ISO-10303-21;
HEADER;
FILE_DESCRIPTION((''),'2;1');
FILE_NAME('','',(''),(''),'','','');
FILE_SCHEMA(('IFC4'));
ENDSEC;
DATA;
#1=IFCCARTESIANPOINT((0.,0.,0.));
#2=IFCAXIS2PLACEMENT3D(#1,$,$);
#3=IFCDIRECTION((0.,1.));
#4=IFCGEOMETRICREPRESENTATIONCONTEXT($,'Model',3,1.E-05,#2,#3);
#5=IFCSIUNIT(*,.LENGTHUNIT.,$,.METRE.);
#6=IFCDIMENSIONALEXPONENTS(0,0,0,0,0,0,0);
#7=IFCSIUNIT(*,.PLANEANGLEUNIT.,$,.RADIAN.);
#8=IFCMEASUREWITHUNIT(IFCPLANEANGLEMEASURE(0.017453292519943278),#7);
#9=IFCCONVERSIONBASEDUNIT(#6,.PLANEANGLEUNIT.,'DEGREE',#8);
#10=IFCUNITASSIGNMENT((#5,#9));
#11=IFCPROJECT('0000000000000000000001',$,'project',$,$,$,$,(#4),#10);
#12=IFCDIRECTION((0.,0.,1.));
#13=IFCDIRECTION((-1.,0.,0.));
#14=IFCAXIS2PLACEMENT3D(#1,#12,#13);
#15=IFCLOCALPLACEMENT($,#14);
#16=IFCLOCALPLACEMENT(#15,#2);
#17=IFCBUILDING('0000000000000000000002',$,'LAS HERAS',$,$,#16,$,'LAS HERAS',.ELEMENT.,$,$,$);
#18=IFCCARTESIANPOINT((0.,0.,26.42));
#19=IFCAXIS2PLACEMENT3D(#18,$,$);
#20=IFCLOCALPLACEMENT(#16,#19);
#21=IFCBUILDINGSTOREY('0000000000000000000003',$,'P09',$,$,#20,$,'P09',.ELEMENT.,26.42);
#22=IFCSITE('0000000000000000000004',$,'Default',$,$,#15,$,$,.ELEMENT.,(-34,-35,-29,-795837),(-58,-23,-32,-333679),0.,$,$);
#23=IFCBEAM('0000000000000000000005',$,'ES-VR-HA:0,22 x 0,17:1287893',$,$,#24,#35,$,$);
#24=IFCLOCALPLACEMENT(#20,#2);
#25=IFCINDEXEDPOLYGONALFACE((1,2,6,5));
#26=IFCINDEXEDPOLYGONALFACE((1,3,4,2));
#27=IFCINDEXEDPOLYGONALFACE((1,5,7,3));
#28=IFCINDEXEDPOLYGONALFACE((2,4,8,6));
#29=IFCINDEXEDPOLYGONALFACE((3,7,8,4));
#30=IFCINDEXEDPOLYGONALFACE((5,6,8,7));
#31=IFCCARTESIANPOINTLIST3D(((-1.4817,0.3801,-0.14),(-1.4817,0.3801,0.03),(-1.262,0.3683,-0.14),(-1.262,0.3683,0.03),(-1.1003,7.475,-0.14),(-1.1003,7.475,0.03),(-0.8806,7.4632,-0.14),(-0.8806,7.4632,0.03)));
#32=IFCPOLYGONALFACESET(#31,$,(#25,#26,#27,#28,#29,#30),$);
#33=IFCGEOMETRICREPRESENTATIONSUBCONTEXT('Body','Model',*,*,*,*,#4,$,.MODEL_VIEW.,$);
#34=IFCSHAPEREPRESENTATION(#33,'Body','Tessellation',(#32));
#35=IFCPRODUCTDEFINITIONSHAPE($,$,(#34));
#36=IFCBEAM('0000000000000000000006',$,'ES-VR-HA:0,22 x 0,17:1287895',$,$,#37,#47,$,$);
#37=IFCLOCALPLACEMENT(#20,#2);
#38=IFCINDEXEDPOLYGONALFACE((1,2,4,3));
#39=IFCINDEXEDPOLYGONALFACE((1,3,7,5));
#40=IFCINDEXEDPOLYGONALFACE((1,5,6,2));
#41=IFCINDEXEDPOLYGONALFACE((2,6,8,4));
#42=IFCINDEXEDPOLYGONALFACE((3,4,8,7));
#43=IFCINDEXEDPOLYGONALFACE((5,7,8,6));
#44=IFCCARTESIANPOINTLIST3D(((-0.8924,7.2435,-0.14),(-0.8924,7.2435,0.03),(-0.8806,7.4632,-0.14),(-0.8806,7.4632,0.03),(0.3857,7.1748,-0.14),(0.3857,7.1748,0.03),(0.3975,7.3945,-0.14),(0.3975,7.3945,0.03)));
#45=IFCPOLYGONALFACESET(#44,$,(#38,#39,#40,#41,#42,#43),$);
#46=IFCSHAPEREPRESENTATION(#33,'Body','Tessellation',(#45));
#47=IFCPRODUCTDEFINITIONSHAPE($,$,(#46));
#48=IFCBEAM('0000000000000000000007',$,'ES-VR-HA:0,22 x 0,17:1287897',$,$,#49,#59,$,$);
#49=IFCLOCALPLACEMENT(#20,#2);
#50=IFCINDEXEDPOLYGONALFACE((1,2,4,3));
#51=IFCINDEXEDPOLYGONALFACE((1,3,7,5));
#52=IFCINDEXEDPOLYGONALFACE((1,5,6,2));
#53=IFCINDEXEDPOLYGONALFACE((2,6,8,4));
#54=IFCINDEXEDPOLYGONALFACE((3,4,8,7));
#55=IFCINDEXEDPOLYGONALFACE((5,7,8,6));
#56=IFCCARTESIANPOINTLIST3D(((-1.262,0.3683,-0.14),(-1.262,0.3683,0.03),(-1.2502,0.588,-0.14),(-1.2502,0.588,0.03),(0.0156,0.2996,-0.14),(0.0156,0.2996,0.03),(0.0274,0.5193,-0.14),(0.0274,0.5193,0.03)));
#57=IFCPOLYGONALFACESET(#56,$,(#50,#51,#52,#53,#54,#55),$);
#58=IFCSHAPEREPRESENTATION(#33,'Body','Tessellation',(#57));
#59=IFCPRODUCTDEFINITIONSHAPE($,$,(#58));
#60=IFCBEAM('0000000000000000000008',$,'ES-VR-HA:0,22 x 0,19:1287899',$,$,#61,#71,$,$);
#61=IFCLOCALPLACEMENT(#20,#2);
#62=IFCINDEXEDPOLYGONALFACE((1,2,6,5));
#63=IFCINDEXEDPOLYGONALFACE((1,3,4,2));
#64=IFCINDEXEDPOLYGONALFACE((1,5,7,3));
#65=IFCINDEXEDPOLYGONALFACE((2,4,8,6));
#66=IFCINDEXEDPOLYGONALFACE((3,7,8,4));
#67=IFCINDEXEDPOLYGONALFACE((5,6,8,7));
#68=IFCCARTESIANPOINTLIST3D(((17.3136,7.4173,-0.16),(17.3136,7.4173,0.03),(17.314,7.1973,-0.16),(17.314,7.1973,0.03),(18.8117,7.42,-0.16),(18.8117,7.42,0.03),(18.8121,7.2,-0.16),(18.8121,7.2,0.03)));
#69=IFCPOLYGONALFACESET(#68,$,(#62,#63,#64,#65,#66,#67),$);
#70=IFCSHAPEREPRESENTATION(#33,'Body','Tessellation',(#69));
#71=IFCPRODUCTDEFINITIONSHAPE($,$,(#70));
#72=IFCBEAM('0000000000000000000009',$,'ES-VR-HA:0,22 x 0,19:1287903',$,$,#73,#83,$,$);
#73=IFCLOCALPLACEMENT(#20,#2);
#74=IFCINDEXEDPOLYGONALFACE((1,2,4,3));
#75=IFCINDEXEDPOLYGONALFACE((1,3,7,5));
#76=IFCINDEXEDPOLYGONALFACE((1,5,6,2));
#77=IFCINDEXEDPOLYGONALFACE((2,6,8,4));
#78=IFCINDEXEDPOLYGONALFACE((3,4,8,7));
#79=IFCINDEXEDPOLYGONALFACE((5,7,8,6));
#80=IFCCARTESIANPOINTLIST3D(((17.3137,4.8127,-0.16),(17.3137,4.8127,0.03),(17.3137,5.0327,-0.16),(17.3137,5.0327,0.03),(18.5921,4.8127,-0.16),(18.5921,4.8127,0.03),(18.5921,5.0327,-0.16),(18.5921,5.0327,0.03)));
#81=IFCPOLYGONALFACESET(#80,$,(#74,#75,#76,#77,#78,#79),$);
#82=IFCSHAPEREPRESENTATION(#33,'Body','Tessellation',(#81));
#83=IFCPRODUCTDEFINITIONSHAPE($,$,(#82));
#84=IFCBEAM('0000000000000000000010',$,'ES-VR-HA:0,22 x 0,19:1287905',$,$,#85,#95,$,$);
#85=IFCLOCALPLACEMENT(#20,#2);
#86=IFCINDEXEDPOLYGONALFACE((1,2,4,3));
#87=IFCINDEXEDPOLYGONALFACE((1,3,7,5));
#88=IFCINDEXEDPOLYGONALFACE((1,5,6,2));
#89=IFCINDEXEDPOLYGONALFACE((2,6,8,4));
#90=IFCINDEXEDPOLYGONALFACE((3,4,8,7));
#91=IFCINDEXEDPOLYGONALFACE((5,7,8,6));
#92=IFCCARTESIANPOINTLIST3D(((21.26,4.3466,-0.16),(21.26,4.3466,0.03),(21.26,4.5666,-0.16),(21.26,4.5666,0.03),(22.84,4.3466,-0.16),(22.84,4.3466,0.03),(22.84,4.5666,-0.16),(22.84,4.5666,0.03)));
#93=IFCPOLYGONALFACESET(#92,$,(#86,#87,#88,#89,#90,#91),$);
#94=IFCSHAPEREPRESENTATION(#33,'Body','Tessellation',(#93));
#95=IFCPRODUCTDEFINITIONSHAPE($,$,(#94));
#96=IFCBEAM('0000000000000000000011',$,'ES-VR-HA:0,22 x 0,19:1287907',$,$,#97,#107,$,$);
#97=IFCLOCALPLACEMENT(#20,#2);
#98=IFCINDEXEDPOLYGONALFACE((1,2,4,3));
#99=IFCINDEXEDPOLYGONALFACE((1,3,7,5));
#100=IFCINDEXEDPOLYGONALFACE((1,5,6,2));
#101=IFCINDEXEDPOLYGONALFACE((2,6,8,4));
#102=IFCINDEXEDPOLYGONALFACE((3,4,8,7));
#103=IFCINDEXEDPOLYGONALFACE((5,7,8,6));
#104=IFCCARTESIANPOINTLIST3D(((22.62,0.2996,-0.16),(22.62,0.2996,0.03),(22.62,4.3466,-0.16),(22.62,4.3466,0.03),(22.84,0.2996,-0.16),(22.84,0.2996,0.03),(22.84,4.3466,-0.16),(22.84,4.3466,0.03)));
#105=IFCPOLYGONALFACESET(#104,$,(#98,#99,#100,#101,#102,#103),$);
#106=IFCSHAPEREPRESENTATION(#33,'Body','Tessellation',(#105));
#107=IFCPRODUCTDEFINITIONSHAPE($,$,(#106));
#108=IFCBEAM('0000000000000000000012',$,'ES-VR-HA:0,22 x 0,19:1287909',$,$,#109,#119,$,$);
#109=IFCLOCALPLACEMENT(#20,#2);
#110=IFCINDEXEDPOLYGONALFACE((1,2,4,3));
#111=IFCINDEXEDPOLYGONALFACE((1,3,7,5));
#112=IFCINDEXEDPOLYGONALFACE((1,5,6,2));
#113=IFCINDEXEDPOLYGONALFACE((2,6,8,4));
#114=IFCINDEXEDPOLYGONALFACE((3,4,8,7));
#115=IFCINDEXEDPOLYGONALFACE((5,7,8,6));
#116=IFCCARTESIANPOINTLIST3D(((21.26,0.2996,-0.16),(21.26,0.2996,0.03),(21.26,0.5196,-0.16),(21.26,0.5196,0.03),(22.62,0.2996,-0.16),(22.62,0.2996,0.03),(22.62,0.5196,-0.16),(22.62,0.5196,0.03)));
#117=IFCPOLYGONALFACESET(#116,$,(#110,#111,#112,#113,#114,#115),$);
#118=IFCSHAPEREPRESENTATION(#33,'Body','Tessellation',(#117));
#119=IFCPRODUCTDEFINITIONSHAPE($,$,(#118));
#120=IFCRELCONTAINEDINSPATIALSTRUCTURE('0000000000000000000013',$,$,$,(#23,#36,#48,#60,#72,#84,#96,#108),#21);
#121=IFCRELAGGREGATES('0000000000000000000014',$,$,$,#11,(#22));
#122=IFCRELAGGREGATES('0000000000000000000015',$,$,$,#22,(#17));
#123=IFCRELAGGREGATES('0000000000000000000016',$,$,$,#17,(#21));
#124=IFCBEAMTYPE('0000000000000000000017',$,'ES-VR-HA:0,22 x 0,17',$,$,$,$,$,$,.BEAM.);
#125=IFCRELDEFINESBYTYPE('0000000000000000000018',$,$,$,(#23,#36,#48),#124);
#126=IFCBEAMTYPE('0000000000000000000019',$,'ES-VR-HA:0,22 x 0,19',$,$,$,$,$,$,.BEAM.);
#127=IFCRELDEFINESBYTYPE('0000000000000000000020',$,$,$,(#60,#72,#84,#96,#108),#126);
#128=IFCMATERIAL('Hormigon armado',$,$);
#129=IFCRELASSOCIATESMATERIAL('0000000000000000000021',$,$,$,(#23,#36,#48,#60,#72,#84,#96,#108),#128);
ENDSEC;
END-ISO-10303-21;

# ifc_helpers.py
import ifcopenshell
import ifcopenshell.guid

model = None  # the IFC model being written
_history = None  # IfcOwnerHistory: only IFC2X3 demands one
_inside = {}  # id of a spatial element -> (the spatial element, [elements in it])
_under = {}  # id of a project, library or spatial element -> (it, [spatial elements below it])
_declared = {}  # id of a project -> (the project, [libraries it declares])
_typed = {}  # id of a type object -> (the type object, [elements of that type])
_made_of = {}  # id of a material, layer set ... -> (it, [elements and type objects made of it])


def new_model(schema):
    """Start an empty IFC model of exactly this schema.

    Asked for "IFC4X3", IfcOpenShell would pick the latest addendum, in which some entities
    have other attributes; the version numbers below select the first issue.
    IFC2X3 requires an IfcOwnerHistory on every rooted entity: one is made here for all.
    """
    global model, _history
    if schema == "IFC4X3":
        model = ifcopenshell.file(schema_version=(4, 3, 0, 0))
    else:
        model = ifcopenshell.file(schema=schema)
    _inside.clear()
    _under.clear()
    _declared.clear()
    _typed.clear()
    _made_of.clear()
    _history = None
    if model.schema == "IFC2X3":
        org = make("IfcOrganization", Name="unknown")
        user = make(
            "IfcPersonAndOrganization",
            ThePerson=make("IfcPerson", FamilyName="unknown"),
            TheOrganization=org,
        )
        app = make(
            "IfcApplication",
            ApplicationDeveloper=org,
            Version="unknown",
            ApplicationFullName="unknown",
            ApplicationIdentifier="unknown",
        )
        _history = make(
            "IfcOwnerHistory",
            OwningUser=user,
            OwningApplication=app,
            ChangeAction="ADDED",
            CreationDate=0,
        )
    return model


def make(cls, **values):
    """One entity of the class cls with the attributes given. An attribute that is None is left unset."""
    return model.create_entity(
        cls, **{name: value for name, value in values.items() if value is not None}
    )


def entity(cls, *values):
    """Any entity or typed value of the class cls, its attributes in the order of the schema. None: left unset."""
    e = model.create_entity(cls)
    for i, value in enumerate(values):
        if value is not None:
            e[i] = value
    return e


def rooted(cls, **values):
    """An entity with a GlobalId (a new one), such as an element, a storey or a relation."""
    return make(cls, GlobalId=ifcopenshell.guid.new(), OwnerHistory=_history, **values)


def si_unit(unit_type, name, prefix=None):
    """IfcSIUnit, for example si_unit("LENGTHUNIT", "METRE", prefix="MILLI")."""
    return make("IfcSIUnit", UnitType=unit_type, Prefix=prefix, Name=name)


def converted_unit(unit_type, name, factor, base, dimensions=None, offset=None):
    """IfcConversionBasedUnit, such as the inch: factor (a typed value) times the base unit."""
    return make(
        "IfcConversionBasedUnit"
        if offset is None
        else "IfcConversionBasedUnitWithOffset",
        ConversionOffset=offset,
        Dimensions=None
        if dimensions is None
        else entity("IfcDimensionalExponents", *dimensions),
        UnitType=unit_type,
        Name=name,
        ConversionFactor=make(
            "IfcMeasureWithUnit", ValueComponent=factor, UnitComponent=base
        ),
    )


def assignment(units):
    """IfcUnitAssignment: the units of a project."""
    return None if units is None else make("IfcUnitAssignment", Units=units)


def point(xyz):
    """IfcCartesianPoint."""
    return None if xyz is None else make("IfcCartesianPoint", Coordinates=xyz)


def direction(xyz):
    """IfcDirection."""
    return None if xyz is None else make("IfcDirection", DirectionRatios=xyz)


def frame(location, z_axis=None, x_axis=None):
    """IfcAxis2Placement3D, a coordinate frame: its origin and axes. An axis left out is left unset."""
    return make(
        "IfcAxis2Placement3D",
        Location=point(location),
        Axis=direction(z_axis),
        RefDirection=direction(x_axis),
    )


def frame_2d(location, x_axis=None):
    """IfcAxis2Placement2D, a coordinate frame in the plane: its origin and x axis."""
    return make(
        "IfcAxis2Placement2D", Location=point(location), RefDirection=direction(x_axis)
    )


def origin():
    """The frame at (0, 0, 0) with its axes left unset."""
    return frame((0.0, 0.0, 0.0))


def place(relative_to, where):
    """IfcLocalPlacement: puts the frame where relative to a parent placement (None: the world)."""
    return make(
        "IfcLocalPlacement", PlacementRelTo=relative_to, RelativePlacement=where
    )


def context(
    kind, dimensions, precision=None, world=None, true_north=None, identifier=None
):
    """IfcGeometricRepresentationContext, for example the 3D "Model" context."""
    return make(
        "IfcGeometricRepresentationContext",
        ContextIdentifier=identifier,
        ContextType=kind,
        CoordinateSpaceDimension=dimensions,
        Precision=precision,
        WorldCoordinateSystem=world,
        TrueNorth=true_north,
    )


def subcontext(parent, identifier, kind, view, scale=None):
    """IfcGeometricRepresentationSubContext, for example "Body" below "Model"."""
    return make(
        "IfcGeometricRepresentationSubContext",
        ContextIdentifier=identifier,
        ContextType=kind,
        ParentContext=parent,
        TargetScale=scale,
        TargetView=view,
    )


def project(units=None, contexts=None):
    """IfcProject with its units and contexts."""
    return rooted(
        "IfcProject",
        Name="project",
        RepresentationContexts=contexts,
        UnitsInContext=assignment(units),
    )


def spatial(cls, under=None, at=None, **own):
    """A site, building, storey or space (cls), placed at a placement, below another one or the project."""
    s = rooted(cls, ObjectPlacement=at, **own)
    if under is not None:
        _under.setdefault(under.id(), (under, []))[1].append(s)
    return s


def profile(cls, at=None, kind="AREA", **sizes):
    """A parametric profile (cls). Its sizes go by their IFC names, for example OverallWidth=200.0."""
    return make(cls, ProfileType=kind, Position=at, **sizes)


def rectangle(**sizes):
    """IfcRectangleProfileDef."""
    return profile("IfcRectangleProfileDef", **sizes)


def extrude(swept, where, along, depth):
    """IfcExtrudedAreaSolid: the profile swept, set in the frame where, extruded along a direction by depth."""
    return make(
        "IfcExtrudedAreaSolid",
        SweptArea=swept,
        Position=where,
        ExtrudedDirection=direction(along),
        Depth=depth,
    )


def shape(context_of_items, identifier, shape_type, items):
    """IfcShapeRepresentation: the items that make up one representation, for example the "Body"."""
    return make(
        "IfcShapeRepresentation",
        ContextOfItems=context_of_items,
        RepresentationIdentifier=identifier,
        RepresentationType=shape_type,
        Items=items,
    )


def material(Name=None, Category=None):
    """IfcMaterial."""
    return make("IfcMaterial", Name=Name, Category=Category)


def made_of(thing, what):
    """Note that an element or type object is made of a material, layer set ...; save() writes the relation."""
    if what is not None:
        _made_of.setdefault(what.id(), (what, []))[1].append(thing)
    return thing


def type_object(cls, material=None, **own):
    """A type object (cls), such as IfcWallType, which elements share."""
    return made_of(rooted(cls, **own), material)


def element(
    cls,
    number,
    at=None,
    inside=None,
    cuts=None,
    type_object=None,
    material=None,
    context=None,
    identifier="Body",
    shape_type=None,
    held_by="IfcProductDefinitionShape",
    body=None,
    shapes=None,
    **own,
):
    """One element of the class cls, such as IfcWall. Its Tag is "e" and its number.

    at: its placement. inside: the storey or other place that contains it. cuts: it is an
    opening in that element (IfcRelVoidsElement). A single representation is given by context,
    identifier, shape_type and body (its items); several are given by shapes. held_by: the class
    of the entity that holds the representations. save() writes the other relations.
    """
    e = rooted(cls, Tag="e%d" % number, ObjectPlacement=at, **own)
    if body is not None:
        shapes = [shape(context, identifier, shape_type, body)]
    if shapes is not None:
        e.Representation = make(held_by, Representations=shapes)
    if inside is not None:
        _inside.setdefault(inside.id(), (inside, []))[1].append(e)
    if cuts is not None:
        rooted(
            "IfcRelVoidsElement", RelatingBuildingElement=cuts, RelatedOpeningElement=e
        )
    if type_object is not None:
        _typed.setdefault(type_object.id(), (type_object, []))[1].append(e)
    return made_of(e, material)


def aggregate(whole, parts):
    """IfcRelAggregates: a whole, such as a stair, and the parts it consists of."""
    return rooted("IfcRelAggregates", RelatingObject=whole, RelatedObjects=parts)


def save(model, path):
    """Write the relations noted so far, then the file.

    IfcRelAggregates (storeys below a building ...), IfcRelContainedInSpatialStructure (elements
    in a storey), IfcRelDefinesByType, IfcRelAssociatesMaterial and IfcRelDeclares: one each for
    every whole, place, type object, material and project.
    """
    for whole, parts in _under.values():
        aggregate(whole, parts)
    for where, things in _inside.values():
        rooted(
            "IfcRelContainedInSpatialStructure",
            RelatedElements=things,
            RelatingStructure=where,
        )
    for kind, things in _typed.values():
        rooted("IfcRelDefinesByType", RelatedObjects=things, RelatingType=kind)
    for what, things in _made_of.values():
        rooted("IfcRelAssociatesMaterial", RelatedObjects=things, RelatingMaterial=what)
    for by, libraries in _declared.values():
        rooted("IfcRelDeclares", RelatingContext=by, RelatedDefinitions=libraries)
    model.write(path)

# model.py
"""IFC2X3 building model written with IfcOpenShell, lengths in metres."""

from ifc_helpers import new_model, entity, si_unit, converted_unit, direction, frame, frame_2d, origin, place, context, subcontext, project, spatial, rectangle, extrude, material, type_object, element, save


model = new_model("IFC2X3")

# Units and contexts
model_context = context("Model", 3, precision=1e-05, world=origin(), true_north=direction((0.0, 1.0)))
body_context = subcontext(model_context, "Body", "Model", "MODEL_VIEW")
ifc_project = project(units=[si_unit("LENGTHUNIT", "METRE"), converted_unit("PLANEANGLEUNIT", "DEGREE", entity("IfcPlaneAngleMeasure", 0.017453292519943278), si_unit("PLANEANGLEUNIT", "RADIAN"), dimensions=[0, 0, 0, 0, 0, 0, 0])], contexts=[model_context])

# Site, building, storey
site_placement = place(None, frame((0.0, 0.0, 0.0), z_axis=(0.0, 0.0, 1.0), x_axis=(-1.0, 0.0, 0.0)))
site = spatial("IfcSite", under=ifc_project, at=site_placement, Name="Default", CompositionType="ELEMENT", RefLatitude=(-34, -35, -29, -795837), RefLongitude=(-58, -23, -32, -333679), RefElevation=0.0)
building_placement = place(site_placement, origin())
building = spatial("IfcBuilding", under=site, at=building_placement, Name="LAS HERAS", LongName="LAS HERAS", CompositionType="ELEMENT")
storey_placement = place(building_placement, frame((0.0, 0.0, 26.42)))
storey = spatial("IfcBuildingStorey", under=building, at=storey_placement, Name="P09", LongName="P09", CompositionType="ELEMENT", Elevation=26.42)

# Beams
ifc_material = material(Name="Hormigon armado")
beam_type_1 = type_object("IfcBeamType", Name="ES-VR-HA:0,22 x 0,17", PredefinedType="BEAM")
beam_1_placement = place(storey_placement, frame((-0.9963, 7.3593, 0.03), z_axis=(0.0, 0.0, 1.0), x_axis=(-0.05369, -0.998558, 0.0)))
element("IfcBeam", 1, at=beam_1_placement, inside=storey, type_object=beam_type_1, material=ifc_material, Name="ES-VR-HA:0,22 x 0,17:1287893", context=body_context, shape_type="SweptSolid", body=[
    extrude(rectangle(XDim=0.17, YDim=0.22, at=frame_2d((0.0, 0.0), x_axis=(1.0, 0.0))), frame((-0.11, 0.0, -0.085), z_axis=(1.0, 0.0, 0.0), x_axis=(0.0, 0.0, -1.0)), (0.0, 0.0, 1.0), 7.1052),
])
beam_2_placement = place(storey_placement, frame((0.3916, 7.2846, 0.03), z_axis=(0.0, 0.0, 1.0), x_axis=(-0.998558, 0.05368, 0.0)))
element("IfcBeam", 2, at=beam_2_placement, inside=storey, type_object=beam_type_1, material=ifc_material, Name="ES-VR-HA:0,22 x 0,17:1287895", context=body_context, shape_type="SweptSolid", body=[
    extrude(rectangle(XDim=0.17, YDim=0.22, at=frame_2d((0.0, 0.0), x_axis=(1.0, 0.0))), frame((0.0, 0.0, -0.085), z_axis=(1.0, 0.0, 0.0), x_axis=(0.0, 0.0, -1.0)), (0.0, 0.0, 1.0), 1.28),
])
beam_3_placement = place(storey_placement, frame((0.0215, 0.4094, 0.03), z_axis=(0.0, 0.0, 1.0), x_axis=(-0.998558, 0.05369, 0.0)))
element("IfcBeam", 3, at=beam_3_placement, inside=storey, type_object=beam_type_1, material=ifc_material, Name="ES-VR-HA:0,22 x 0,17:1287897", context=body_context, shape_type="SweptSolid", body=[
    extrude(rectangle(XDim=0.17, YDim=0.22, at=frame_2d((0.0, 0.0), x_axis=(1.0, 0.0))), frame((0.0, 0.0, -0.085), z_axis=(1.0, 0.0, 0.0), x_axis=(0.0, 0.0, -1.0)), (0.0, 0.0, 1.0), 1.2795),
])
beam_type_2 = type_object("IfcBeamType", Name="ES-VR-HA:0,22 x 0,19", PredefinedType="BEAM")
beam_4_placement = place(storey_placement, frame((17.3138, 7.3073, 0.03), z_axis=(0.0, 0.0, 1.0), x_axis=(0.999998, 0.001781, 0.0)))
element("IfcBeam", 4, at=beam_4_placement, inside=storey, type_object=beam_type_2, material=ifc_material, Name="ES-VR-HA:0,22 x 0,19:1287899", context=body_context, shape_type="SweptSolid", body=[
    extrude(rectangle(XDim=0.19, YDim=0.22, at=frame_2d((0.0, 0.0), x_axis=(1.0, 0.0))), frame((0.0, 0.0, -0.095), z_axis=(1.0, 0.0, 0.0), x_axis=(0.0, 0.0, -1.0)), (0.0, 0.0, 1.0), 1.4981),
])
beam_5_placement = place(storey_placement, frame((17.3137, 4.9227, 0.03)))
element("IfcBeam", 5, at=beam_5_placement, inside=storey, type_object=beam_type_2, material=ifc_material, Name="ES-VR-HA:0,22 x 0,19:1287903", context=body_context, shape_type="SweptSolid", body=[
    extrude(rectangle(XDim=0.19, YDim=0.22, at=frame_2d((0.0, 0.0), x_axis=(1.0, 0.0))), frame((0.0, 0.0, -0.095), z_axis=(1.0, 0.0, 0.0), x_axis=(0.0, 0.0, -1.0)), (0.0, 0.0, 1.0), 1.2784),
])
beam_6_placement = place(storey_placement, frame((21.26, 4.4566, 0.03)))
element("IfcBeam", 6, at=beam_6_placement, inside=storey, type_object=beam_type_2, material=ifc_material, Name="ES-VR-HA:0,22 x 0,19:1287905", context=body_context, shape_type="SweptSolid", body=[
    extrude(rectangle(XDim=0.19, YDim=0.22, at=frame_2d((0.0, 0.0), x_axis=(1.0, 0.0))), frame((0.0, 0.0, -0.095), z_axis=(1.0, 0.0, 0.0), x_axis=(0.0, 0.0, -1.0)), (0.0, 0.0, 1.0), 1.58),
])
beam_7_placement = place(storey_placement, frame((22.73, 4.4566, 0.03), z_axis=(0.0, 0.0, 1.0), x_axis=(0.0, -1.0, 0.0)))
element("IfcBeam", 7, at=beam_7_placement, inside=storey, type_object=beam_type_2, material=ifc_material, Name="ES-VR-HA:0,22 x 0,19:1287907", context=body_context, shape_type="SweptSolid", body=[
    extrude(rectangle(XDim=0.19, YDim=0.22, at=frame_2d((0.0, 0.0), x_axis=(1.0, 0.0))), frame((0.11, 0.0, -0.095), z_axis=(1.0, 0.0, 0.0), x_axis=(0.0, 0.0, -1.0)), (0.0, 0.0, 1.0), 4.0471),
])
beam_8_placement = place(storey_placement, frame((21.26, 0.4096, 0.03)))
element("IfcBeam", 8, at=beam_8_placement, inside=storey, type_object=beam_type_2, material=ifc_material, Name="ES-VR-HA:0,22 x 0,19:1287909", context=body_context, shape_type="SweptSolid", body=[
    extrude(rectangle(XDim=0.19, YDim=0.22, at=frame_2d((0.0, 0.0), x_axis=(1.0, 0.0))), frame((0.0, 0.0, -0.095), z_axis=(1.0, 0.0, 0.0), x_axis=(0.0, 0.0, -1.0)), (0.0, 0.0, 1.0), 1.36),
])

save(model, "model.ifc")
